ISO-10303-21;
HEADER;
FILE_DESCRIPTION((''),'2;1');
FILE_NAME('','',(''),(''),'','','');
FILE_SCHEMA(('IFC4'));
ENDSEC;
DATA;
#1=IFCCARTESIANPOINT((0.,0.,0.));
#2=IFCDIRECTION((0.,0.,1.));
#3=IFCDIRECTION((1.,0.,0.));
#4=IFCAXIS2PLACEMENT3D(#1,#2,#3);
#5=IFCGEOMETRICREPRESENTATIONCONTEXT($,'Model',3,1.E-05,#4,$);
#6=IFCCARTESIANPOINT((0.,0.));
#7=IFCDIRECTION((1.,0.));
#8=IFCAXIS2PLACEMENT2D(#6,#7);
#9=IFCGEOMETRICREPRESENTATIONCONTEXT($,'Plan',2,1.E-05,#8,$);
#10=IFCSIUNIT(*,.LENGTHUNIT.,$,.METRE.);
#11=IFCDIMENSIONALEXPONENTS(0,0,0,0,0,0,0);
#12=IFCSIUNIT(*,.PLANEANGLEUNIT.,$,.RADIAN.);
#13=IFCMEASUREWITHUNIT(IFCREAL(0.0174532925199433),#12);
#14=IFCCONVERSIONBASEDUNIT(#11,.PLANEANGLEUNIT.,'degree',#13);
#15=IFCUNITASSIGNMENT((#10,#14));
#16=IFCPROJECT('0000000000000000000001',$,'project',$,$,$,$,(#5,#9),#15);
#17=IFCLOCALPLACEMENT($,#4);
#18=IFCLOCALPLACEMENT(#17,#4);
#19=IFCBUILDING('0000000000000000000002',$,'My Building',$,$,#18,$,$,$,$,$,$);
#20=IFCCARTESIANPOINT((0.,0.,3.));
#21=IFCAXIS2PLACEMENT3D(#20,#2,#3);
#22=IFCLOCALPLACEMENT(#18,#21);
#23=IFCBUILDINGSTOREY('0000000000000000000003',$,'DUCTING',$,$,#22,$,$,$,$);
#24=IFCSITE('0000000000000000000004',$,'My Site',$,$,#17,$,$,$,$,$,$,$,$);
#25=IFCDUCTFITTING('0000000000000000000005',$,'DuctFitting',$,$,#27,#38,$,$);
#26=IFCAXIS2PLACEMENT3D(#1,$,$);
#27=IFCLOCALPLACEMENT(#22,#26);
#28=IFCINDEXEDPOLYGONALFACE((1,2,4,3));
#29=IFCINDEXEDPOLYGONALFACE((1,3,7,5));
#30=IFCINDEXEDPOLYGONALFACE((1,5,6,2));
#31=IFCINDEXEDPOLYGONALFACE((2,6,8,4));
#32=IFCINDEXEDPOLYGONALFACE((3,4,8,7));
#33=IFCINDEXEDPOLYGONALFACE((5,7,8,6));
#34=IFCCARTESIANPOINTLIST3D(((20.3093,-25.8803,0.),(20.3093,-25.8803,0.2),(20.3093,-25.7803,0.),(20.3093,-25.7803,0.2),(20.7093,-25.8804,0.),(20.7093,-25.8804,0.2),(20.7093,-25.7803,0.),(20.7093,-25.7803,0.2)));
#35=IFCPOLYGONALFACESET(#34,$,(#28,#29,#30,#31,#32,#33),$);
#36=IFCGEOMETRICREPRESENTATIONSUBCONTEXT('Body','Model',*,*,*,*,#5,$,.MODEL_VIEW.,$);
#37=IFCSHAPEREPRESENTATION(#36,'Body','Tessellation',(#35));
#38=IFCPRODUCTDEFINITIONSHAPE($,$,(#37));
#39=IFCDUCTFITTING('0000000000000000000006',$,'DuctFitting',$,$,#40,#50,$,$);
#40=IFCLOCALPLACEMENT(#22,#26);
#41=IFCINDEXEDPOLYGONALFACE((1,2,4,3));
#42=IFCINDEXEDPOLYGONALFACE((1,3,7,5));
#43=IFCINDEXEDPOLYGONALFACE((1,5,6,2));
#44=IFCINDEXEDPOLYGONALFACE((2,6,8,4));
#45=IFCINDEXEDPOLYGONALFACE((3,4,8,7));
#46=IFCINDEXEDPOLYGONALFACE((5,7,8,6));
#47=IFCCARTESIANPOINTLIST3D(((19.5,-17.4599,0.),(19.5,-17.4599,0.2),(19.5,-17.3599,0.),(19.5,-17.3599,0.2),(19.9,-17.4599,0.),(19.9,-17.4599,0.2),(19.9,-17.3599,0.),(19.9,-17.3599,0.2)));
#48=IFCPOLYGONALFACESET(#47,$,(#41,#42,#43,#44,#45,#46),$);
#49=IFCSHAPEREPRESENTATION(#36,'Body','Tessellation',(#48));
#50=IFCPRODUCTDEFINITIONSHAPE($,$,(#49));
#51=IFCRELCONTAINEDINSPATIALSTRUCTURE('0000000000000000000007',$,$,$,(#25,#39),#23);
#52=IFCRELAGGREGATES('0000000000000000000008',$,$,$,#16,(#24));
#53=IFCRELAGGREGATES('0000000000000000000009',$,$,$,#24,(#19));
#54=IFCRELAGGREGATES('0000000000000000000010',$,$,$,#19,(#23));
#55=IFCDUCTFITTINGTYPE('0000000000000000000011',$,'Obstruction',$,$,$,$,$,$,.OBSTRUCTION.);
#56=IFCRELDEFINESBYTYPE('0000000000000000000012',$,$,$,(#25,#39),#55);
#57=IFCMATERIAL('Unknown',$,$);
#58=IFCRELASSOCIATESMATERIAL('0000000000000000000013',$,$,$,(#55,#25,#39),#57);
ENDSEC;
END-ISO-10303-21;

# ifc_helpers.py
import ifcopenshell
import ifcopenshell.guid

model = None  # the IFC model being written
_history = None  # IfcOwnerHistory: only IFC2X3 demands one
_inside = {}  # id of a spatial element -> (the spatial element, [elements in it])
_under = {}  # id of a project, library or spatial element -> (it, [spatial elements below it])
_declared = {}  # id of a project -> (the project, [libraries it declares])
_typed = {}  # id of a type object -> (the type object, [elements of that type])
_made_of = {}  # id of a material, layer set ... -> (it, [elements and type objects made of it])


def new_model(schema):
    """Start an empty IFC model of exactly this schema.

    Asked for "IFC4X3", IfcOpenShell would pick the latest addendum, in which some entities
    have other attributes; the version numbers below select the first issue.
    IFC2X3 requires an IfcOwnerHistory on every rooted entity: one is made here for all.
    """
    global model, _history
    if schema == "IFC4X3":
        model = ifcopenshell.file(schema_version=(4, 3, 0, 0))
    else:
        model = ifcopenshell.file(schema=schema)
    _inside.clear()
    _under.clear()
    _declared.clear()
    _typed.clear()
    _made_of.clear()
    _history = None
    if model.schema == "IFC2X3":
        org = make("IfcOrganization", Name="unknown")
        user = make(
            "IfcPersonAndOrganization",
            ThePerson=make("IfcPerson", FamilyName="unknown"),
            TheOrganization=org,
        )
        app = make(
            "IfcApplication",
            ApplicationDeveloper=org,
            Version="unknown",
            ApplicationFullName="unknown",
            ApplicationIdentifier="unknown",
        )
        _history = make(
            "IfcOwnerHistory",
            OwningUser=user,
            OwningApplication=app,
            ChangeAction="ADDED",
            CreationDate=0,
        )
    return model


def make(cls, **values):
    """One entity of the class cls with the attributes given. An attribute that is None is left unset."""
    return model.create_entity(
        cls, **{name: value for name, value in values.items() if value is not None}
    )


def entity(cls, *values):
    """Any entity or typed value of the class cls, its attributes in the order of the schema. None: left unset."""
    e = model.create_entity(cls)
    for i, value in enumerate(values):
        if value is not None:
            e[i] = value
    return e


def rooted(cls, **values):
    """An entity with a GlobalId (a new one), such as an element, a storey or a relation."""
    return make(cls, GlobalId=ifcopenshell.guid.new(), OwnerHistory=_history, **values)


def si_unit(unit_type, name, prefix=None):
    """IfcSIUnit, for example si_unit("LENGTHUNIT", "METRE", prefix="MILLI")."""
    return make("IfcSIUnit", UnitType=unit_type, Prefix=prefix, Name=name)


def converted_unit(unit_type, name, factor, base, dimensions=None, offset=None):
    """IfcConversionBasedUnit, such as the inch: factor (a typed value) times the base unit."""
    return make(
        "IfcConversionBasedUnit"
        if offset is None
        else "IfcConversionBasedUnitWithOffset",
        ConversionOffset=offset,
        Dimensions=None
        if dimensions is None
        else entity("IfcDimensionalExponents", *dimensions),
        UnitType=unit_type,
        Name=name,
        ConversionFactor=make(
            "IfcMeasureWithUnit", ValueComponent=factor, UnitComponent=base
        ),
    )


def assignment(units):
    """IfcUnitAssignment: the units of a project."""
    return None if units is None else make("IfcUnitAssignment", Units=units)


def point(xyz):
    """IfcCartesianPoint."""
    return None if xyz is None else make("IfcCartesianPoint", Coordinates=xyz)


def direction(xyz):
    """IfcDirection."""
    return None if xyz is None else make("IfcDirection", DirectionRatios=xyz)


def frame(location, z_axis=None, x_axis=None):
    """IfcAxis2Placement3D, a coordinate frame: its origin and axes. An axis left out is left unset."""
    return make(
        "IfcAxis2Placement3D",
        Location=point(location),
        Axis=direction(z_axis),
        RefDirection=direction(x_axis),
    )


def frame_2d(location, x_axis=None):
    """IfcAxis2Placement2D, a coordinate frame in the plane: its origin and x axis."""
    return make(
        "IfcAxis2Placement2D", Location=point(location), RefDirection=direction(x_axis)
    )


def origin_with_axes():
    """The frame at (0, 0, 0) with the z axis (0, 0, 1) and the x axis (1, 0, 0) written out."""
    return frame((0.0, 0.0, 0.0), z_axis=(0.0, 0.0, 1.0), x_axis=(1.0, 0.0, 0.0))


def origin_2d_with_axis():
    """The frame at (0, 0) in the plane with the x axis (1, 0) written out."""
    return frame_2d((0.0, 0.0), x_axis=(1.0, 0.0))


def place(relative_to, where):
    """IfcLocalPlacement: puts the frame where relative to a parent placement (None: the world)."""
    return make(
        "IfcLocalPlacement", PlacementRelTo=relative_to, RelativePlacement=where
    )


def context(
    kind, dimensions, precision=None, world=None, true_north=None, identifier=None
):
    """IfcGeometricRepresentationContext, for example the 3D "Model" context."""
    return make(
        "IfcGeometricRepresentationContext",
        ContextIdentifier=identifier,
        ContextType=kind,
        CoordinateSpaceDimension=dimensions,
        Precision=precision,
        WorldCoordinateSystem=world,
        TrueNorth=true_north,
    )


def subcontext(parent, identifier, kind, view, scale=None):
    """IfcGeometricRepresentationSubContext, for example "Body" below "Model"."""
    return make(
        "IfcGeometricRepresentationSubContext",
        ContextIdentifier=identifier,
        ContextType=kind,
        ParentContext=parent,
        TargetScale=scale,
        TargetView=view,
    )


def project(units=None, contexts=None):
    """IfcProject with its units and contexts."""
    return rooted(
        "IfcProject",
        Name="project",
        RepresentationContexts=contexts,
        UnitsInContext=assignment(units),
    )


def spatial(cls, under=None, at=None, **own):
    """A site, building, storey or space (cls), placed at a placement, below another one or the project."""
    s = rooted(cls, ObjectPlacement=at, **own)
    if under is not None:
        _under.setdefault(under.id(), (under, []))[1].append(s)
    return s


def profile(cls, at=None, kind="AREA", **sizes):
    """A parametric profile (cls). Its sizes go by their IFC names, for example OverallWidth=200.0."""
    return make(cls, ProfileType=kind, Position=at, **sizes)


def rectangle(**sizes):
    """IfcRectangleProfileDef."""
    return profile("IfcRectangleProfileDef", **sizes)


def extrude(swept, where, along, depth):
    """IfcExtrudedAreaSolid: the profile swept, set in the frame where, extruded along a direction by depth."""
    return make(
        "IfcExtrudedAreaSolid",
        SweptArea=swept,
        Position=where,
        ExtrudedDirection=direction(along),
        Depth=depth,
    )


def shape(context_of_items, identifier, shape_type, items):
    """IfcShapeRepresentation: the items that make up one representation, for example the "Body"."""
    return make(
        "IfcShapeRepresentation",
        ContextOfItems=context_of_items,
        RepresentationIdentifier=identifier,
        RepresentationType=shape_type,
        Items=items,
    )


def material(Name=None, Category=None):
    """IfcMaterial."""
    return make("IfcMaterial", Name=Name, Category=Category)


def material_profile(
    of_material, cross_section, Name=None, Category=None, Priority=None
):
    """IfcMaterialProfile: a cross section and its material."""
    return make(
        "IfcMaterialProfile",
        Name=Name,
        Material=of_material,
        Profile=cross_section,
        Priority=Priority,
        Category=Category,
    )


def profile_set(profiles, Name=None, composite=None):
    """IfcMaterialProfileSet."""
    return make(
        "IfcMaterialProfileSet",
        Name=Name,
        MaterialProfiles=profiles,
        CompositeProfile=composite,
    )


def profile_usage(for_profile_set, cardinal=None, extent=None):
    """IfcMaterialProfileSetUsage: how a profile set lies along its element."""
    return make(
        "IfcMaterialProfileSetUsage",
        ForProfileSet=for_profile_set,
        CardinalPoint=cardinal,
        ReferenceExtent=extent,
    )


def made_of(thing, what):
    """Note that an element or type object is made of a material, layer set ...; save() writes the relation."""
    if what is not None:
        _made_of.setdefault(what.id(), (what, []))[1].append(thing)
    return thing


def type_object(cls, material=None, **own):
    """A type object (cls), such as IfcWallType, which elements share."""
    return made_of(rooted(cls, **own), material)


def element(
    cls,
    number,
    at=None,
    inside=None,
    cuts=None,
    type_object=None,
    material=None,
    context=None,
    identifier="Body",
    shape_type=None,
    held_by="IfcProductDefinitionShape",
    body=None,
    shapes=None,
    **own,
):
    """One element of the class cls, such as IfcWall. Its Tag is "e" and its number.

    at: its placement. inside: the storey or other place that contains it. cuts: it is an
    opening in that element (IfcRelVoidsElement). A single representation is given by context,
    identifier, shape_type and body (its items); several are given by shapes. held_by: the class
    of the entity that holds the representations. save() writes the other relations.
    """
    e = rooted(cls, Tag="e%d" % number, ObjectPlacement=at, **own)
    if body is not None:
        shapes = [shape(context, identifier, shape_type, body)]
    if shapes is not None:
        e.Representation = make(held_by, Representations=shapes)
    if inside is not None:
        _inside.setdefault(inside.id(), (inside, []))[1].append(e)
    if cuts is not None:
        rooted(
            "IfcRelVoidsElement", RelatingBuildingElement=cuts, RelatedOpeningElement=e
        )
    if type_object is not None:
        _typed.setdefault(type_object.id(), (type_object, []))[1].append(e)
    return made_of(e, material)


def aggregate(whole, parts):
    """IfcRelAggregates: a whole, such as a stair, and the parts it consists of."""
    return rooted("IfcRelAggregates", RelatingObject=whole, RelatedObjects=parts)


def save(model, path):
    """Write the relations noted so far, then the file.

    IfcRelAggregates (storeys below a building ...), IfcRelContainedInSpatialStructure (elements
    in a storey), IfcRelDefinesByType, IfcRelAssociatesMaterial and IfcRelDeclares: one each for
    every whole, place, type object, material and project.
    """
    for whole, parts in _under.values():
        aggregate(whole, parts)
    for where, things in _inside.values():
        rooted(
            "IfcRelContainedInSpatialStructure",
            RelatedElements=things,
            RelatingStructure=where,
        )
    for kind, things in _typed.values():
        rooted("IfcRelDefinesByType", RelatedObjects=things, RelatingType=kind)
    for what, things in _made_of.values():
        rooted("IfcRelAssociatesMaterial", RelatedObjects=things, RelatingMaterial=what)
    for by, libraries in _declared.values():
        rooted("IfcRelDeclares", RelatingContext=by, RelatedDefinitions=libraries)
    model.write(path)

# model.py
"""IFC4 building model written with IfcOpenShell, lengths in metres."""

from ifc_helpers import new_model, entity, si_unit, converted_unit, frame, origin_with_axes, origin_2d_with_axis, place, context, subcontext, project, spatial, rectangle, extrude, material, material_profile, profile_set, profile_usage, type_object, element, save


model = new_model("IFC4")

# Units and contexts
model_context = context("Model", 3, precision=1e-05, world=origin_with_axes())
plan_context = context("Plan", 2, precision=1e-05, world=origin_2d_with_axis())
body_context = subcontext(model_context, "Body", "Model", "MODEL_VIEW")
ifc_project = project(units=[si_unit("LENGTHUNIT", "METRE"), converted_unit("PLANEANGLEUNIT", "degree", entity("IfcReal", 0.0174532925199433), si_unit("PLANEANGLEUNIT", "RADIAN"), dimensions=[0, 0, 0, 0, 0, 0, 0])], contexts=[model_context, plan_context])

# Site, building, storey
site_placement = place(None, origin_with_axes())
site = spatial("IfcSite", under=ifc_project, at=site_placement, Name="My Site")
building_placement = place(site_placement, origin_with_axes())
building = spatial("IfcBuilding", under=site, at=building_placement, Name="My Building")
storey_placement = place(building_placement, frame((0.0, 0.0, 3.0), z_axis=(0.0, 0.0, 1.0), x_axis=(1.0, 0.0, 0.0)))
storey = spatial("IfcBuildingStorey", under=building, at=storey_placement, Name="DUCTING")

# Shared definitions
ifc_material = material(Name="Unknown")

# Duct fittings
ifc_material_profile_1 = material_profile(ifc_material, rectangle(XDim=0.4, YDim=0.2))
ifc_profile_set_1 = profile_set([ifc_material_profile_1])
duct_fitting_type_1 = type_object("IfcDuctFittingType", Name="Obstruction", PredefinedType="OBSTRUCTION", material=ifc_profile_set_1)
ifc_profile_usage_1 = profile_usage(ifc_profile_set_1, cardinal=5)
duct_fitting_1_placement = place(storey_placement, frame((20.5093, -25.8804, 0.1), z_axis=(0.000001, 1.0, 0.0), x_axis=(-1.0, 0.000001, 0.0)))
element("IfcDuctFitting", 1, at=duct_fitting_1_placement, inside=storey, type_object=duct_fitting_type_1, material=ifc_profile_usage_1, Name="DuctFitting", context=body_context, shape_type="SweptSolid", body=[
    extrude(rectangle(XDim=0.4, YDim=0.2), origin_with_axes(), (0.0, 0.0, 1.0), 0.1),
])
ifc_profile_usage_2 = profile_usage(ifc_profile_set_1, cardinal=5)
duct_fitting_2_placement = place(storey_placement, frame((19.7, -17.4599, 0.1), z_axis=(0.000001, 1.0, 0.0), x_axis=(-1.0, 0.000001, 0.0)))
element("IfcDuctFitting", 2, at=duct_fitting_2_placement, inside=storey, type_object=duct_fitting_type_1, material=ifc_profile_usage_2, Name="DuctFitting", context=body_context, shape_type="SweptSolid", body=[
    extrude(rectangle(XDim=0.4, YDim=0.2), origin_with_axes(), (0.0, 0.0, 1.0), 0.1),
])

save(model, "model.ifc")
